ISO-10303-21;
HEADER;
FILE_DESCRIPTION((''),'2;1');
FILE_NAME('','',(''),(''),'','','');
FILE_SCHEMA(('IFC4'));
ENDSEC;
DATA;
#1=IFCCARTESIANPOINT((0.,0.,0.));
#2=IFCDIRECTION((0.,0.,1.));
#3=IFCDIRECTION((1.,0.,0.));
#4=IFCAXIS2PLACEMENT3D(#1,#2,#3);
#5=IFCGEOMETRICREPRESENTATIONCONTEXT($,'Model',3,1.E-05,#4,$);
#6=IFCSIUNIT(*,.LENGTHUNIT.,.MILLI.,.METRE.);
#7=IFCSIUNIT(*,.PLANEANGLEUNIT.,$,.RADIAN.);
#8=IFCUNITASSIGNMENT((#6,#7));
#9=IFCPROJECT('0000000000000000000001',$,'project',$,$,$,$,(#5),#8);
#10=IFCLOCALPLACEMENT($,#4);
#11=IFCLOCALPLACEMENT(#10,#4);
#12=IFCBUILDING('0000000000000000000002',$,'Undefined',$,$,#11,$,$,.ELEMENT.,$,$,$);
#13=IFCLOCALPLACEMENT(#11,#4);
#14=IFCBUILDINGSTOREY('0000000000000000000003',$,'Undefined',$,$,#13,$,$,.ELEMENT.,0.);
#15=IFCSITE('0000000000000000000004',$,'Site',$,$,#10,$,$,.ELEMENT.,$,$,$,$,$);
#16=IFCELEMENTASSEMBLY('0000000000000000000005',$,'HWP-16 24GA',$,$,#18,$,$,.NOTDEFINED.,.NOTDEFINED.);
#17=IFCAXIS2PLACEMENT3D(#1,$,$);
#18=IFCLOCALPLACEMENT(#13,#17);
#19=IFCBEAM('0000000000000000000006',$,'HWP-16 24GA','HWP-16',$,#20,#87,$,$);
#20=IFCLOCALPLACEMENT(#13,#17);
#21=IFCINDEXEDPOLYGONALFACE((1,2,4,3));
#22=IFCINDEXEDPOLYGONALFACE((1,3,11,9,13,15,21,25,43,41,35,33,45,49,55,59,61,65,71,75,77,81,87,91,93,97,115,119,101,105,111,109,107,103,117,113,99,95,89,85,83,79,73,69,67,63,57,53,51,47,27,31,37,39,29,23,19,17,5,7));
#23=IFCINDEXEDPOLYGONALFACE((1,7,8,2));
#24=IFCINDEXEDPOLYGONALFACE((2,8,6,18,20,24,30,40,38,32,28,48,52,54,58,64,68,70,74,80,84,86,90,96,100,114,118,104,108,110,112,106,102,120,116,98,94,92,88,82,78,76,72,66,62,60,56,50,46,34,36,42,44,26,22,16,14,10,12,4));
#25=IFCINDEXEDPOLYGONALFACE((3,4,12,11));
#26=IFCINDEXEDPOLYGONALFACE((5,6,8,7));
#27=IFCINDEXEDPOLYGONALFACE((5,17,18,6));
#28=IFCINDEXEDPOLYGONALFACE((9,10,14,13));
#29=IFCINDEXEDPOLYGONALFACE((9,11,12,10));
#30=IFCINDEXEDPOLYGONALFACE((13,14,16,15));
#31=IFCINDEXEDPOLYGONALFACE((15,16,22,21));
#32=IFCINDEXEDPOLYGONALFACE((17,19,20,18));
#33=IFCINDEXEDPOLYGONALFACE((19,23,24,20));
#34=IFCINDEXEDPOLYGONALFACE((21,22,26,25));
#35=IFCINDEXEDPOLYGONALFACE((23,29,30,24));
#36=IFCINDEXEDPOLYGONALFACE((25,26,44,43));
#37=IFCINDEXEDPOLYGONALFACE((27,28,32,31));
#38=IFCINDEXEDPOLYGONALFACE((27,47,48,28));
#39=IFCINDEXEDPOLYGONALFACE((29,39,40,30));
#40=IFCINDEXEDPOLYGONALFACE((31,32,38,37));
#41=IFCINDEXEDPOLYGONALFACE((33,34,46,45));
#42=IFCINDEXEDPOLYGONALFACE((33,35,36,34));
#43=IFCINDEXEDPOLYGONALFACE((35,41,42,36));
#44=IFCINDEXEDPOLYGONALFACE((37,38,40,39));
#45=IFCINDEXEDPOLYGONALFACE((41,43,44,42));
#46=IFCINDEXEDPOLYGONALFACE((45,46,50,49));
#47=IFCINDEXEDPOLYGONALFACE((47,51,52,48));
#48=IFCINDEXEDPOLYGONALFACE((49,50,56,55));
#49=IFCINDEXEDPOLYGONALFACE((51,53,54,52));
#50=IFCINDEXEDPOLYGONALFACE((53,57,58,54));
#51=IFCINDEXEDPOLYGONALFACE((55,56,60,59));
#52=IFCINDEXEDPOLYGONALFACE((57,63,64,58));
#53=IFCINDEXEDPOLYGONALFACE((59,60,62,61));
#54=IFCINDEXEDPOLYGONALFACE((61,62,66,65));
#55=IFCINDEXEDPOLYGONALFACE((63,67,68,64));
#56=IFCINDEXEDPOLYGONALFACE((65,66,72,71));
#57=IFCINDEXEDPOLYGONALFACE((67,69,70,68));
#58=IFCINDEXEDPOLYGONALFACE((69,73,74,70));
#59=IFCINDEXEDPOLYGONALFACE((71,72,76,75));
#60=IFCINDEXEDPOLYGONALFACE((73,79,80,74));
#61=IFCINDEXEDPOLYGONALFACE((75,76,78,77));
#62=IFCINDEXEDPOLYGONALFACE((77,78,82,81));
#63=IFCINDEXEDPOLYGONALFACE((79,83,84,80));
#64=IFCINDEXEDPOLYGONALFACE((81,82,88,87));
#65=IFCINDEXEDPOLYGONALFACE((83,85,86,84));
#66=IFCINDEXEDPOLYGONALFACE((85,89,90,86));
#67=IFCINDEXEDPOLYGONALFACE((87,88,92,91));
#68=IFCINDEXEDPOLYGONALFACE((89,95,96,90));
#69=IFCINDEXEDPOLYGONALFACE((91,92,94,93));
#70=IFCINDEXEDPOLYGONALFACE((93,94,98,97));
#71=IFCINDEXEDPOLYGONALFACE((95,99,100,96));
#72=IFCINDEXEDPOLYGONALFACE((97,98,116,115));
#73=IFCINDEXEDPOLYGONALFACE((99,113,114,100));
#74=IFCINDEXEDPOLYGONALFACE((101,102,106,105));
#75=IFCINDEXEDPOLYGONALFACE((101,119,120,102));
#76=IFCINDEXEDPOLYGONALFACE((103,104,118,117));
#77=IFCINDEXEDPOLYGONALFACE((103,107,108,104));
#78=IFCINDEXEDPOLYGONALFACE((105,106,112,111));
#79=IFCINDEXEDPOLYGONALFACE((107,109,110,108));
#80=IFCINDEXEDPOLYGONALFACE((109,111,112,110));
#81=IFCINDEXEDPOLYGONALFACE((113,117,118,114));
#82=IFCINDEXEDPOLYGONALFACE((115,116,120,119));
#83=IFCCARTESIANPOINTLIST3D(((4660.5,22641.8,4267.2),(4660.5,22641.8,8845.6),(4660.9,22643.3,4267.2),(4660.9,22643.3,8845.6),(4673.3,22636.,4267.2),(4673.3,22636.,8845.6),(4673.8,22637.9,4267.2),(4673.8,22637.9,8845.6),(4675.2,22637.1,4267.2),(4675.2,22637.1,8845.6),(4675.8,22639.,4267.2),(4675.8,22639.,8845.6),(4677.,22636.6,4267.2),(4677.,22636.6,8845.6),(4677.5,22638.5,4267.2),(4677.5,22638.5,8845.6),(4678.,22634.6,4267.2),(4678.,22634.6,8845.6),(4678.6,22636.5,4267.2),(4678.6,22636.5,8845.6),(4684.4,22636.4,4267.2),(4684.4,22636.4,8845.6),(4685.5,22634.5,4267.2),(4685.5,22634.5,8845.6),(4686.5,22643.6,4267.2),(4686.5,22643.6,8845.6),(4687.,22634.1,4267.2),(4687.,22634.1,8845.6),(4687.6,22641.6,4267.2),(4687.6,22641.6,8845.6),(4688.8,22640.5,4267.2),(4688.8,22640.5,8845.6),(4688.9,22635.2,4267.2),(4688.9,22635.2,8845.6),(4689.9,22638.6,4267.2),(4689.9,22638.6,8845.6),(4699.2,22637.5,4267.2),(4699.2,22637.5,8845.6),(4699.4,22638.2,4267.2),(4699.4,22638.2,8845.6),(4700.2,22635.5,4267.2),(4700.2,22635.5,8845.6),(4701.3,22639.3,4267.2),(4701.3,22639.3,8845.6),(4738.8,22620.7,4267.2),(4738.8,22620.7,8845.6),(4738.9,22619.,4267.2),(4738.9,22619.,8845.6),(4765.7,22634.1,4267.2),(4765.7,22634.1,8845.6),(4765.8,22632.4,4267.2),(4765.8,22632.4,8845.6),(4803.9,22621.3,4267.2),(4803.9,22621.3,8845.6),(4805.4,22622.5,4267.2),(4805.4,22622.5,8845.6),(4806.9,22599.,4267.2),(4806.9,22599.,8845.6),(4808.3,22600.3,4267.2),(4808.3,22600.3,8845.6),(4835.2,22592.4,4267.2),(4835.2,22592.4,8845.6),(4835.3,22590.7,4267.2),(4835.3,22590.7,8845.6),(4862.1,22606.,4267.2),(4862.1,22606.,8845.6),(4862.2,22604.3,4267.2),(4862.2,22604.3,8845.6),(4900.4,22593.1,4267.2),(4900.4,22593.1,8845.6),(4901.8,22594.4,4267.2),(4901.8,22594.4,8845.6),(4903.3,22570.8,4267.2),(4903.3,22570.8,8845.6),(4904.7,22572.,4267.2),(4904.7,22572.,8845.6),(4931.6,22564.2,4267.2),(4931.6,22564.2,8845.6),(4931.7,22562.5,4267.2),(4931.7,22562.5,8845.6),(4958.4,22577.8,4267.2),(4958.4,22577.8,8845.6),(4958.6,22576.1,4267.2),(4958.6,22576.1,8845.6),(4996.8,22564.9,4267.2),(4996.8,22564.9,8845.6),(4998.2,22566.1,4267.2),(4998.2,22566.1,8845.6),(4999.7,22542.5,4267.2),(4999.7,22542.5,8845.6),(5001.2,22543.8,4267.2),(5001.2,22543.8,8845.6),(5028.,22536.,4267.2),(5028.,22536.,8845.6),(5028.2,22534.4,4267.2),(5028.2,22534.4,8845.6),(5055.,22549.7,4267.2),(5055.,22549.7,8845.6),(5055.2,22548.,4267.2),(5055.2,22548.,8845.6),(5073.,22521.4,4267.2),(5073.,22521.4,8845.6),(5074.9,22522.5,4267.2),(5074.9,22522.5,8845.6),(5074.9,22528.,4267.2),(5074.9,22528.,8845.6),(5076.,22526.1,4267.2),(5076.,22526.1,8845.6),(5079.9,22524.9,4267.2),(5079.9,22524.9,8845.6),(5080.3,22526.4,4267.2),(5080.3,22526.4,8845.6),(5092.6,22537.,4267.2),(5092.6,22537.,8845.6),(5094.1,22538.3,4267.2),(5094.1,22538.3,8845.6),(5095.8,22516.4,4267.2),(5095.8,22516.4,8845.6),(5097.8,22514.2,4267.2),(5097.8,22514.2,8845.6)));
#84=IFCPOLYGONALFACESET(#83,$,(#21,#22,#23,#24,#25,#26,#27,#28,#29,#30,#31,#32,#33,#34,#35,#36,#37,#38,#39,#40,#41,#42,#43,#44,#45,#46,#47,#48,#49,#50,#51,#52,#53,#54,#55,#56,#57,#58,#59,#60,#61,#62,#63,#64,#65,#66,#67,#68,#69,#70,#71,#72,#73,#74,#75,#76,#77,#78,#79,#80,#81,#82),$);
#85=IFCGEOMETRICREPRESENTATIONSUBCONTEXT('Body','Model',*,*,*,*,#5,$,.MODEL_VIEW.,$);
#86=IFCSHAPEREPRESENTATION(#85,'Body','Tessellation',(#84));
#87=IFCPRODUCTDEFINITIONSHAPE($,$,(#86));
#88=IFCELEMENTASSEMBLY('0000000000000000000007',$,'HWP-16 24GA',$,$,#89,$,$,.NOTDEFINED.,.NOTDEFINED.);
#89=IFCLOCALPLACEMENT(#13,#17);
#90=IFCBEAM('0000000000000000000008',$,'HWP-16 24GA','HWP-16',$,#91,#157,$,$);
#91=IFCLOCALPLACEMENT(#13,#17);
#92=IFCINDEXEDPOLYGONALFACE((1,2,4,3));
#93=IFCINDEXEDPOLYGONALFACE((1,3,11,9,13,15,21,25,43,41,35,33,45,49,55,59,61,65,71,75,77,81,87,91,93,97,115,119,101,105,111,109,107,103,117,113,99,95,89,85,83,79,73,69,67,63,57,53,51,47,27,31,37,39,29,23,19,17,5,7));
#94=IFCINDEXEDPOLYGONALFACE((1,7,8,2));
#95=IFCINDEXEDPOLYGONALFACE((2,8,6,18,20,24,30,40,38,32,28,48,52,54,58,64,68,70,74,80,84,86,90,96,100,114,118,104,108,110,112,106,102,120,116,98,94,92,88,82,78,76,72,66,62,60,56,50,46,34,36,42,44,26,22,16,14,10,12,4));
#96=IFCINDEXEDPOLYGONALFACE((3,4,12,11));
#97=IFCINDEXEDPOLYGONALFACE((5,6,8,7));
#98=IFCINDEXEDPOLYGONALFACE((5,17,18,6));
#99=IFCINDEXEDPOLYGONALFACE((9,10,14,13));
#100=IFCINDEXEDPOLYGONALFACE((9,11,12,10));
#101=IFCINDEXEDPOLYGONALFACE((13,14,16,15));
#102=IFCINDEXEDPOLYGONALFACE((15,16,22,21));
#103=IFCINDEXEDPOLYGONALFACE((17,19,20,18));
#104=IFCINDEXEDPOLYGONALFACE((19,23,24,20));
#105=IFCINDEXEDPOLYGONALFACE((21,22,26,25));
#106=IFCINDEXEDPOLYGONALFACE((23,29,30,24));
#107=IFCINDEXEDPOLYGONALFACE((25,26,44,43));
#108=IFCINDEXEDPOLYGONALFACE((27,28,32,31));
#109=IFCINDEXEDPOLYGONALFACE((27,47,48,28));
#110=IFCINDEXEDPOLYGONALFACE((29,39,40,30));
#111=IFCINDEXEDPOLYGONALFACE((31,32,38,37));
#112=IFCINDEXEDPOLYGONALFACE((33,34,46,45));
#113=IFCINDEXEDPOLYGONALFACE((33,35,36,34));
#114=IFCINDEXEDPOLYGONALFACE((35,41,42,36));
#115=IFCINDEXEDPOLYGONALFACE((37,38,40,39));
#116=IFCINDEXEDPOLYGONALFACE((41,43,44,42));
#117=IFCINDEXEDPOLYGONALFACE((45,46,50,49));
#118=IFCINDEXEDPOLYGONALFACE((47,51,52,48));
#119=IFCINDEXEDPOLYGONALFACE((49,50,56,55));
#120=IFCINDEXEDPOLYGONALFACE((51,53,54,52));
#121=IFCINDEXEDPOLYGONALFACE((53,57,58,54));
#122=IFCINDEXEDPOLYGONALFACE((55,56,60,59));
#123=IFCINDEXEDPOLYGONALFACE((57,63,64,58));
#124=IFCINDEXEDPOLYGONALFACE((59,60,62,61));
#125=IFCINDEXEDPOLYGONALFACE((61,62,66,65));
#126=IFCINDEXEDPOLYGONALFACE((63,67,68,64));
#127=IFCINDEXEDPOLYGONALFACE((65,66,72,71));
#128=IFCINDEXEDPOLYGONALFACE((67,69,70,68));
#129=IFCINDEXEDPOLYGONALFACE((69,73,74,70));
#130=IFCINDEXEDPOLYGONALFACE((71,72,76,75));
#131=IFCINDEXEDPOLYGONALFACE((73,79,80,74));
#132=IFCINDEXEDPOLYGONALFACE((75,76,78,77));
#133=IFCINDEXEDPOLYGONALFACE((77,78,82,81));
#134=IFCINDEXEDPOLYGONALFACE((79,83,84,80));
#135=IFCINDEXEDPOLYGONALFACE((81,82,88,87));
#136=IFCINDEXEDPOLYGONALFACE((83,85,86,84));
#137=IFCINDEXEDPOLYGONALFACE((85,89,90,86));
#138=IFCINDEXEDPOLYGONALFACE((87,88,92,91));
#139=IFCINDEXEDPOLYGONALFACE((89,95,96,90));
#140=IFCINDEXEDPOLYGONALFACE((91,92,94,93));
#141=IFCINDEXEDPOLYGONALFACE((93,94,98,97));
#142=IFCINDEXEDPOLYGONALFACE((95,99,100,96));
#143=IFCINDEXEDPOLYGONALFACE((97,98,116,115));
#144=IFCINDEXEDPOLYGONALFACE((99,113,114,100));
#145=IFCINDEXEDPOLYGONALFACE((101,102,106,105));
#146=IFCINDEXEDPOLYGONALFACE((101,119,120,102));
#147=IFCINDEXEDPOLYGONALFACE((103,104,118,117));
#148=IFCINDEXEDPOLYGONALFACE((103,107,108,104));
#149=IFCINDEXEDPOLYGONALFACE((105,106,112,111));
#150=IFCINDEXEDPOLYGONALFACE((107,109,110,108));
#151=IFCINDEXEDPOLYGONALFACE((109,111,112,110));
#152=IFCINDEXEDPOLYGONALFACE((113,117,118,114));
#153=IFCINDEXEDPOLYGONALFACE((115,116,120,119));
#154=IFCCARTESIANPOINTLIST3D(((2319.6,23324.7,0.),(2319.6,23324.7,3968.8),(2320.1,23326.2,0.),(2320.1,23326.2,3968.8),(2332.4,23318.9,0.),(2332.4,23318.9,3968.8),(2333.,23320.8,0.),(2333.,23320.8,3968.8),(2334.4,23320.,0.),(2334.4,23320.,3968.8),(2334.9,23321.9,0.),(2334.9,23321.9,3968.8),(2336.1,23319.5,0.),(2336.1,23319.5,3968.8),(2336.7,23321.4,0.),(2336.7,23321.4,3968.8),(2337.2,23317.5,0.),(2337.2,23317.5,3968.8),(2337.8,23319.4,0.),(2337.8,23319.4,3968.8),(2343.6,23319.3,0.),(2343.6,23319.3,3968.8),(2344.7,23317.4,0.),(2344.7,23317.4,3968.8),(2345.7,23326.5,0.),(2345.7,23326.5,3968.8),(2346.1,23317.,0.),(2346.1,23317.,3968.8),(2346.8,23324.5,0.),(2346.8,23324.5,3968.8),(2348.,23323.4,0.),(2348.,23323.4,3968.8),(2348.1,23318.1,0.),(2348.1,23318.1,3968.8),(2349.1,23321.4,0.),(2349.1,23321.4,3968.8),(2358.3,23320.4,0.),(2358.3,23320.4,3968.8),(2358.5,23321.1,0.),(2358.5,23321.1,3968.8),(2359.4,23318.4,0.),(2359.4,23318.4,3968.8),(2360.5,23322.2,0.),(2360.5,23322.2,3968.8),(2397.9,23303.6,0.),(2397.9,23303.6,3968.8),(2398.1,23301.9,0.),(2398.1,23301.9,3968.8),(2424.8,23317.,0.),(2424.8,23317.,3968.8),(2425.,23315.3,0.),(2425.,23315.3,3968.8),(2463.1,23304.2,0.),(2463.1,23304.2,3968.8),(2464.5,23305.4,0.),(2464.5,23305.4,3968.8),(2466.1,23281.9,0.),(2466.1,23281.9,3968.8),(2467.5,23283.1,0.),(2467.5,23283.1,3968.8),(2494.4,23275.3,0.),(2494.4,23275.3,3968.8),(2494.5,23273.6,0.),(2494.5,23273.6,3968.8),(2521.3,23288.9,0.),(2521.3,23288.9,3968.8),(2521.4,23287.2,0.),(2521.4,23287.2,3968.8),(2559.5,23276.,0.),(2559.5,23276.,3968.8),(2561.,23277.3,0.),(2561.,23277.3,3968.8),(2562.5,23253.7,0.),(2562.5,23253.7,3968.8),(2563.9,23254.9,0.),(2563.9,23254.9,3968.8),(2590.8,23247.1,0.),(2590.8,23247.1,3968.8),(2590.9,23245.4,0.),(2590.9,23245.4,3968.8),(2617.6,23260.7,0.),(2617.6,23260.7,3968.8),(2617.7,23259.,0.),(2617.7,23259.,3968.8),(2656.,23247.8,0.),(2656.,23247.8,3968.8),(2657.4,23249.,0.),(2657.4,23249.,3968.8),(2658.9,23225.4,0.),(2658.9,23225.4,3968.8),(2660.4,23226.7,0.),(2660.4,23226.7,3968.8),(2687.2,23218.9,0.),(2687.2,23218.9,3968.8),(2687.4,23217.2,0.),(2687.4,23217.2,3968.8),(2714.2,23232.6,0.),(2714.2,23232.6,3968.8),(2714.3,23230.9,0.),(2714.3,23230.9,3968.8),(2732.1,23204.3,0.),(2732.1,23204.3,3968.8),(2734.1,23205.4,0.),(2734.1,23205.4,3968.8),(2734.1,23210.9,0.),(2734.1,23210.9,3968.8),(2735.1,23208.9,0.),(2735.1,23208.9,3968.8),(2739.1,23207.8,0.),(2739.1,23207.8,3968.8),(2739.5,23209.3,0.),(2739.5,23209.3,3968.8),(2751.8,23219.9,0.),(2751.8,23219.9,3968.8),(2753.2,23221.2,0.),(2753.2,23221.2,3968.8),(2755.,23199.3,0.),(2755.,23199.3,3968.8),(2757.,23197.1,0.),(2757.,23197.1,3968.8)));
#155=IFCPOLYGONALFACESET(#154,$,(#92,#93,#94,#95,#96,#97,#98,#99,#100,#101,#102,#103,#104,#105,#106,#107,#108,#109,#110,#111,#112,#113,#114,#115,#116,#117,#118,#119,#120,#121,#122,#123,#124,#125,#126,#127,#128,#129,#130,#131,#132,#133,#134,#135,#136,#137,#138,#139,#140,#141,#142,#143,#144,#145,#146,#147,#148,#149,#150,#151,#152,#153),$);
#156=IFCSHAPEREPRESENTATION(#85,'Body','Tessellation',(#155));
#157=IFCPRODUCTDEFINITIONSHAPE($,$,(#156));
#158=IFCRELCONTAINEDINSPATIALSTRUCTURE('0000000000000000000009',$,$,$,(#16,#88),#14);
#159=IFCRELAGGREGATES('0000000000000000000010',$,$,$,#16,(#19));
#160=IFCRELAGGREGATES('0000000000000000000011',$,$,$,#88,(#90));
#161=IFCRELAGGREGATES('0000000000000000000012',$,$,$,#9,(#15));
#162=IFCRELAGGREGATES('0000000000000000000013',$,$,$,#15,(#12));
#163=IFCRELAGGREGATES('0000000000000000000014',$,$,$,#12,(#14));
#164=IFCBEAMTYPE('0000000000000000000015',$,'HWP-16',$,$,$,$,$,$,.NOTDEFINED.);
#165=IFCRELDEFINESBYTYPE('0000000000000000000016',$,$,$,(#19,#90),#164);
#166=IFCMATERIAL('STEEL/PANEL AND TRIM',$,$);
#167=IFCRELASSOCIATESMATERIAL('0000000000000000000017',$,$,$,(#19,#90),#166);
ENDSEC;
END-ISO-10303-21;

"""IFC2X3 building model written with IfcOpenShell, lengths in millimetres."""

from ifc_helpers import new_model, si_unit, frame, origin_with_axes, place, context, subcontext, project, spatial, polyline, outline, extrude, boolean, clip, halfspace, material, type_object, element, aggregate, save


model = new_model("IFC2X3")

# Units and contexts
model_context = context("Model", 3, precision=1e-05, world=origin_with_axes())
body_context = subcontext(model_context, "Body", "Model", "MODEL_VIEW")
ifc_project = project(units=[si_unit("LENGTHUNIT", "METRE", prefix="MILLI"), si_unit("PLANEANGLEUNIT", "RADIAN")], contexts=[model_context])

# Site, building, storey
site_placement = place(None, origin_with_axes())
site = spatial("IfcSite", under=ifc_project, at=site_placement, Name="Site", CompositionType="ELEMENT")
building_placement = place(site_placement, origin_with_axes())
building = spatial("IfcBuilding", under=site, at=building_placement, Name="Undefined", CompositionType="ELEMENT")
storey_placement = place(building_placement, origin_with_axes())
storey = spatial("IfcBuildingStorey", under=building, at=storey_placement, Name="Undefined", CompositionType="ELEMENT", Elevation=0.0)

# Element assemblies, beams
ifc_material_1 = material(Name="STEEL/PANEL AND TRIM")
beam_type_1 = type_object("IfcBeamType", Name="HWP-16", PredefinedType="NOTDEFINED")
assembly_1_placement = place(storey_placement, origin_with_axes())
assembly_1 = element("IfcElementAssembly", 1, at=assembly_1_placement, inside=storey, Name="HWP-16 24GA", AssemblyPlace="NOTDEFINED", PredefinedType="NOTDEFINED")
beam_1_placement = place(assembly_1_placement, frame((5094.1, 22538.3, 8845.6), z_axis=(-0.280057, -0.959983, 0.0), x_axis=(0.0, 0.0, -1.0)))
beam_1 = element("IfcBeam", 2, at=beam_1_placement, type_object=beam_type_1, material=ifc_material_1, Name="HWP-16 24GA", Description="HWP-16", context=body_context, shape_type="Clipping", body=[
    clip(extrude(outline(polyline([(40.7, 0.0), (0.0, 0.0), (-10.3, 22.1), (15.5, 22.1), (15.5, 15.2), (9.9, 15.2), (9.9, 16.8), (13.9, 16.8), (13.9, 20.5), (-7.8, 20.5), (1.0, 1.6), (40.1, 1.6), (62.1, 22.2), (91.7, 22.3), (100.8, 1.7), (140.6, 1.7), (162.6, 22.2), (192.2, 22.2), (201.3, 1.6), (241.0, 1.6), (263.1, 22.1), (292.7, 22.1), (301.8, 1.6), (341.5, 1.6), (363.5, 22.0), (417.6, 22.0), (417.6, 15.3), (406.9, 15.3), (406.9, 14.6), (419.2, 14.6), (419.2, 22.1), (426.4, 22.1), (426.4, 24.0), (431.3, 24.0), (431.3, 22.1), (445.2, 22.1), (445.2, 20.5), (429.7, 20.5), (429.7, 22.5), (427.9, 22.5), (427.9, 20.5), (420.7, 20.5), (420.7, 13.0), (405.3, 13.0), (405.3, 16.9), (416.0, 16.9), (416.0, 20.4), (364.1, 20.4), (342.1, 0.0), (300.7, 0.0), (291.6, 20.5), (263.7, 20.5), (241.6, 0.0), (200.3, 0.0), (191.2, 20.6), (163.2, 20.6), (141.3, 0.1), (99.8, 0.1), (90.7, 20.7), (62.7, 20.6), (40.7, 0.0)])), frame((10000.0, 0.0, 0.0), z_axis=(-1.0, 0.0, 0.0), x_axis=(0.0, -1.0, 0.0)), (0.0, 0.0, 1.0), 10000.0), halfspace(frame((4578.4, -500.0, -500.0), z_axis=(1.0, 0.0, 0.0), x_axis=(0.0, 0.0, 1.0)), False)),
])
aggregate(assembly_1, [beam_1])
assembly_2_placement = place(storey_placement, origin_with_axes())
assembly_2 = element("IfcElementAssembly", 3, at=assembly_2_placement, inside=storey, Name="HWP-16 24GA", AssemblyPlace="NOTDEFINED", PredefinedType="NOTDEFINED")
beam_2_placement = place(assembly_2_placement, frame((2753.2, 23221.2, 3968.8), z_axis=(-0.280057, -0.959983, 0.0), x_axis=(0.0, 0.0, -1.0)))
beam_2 = element("IfcBeam", 4, at=beam_2_placement, type_object=beam_type_1, material=ifc_material_1, Name="HWP-16 24GA", Description="HWP-16", context=body_context, shape_type="CSG", body=[
    boolean("DIFFERENCE", boolean("DIFFERENCE", extrude(outline(polyline([(40.7, 0.0), (0.0, 0.0), (-10.3, 22.1), (15.5, 22.1), (15.5, 15.2), (9.9, 15.2), (9.9, 16.8), (13.9, 16.8), (13.9, 20.5), (-7.8, 20.5), (1.0, 1.6), (40.1, 1.6), (62.1, 22.2), (91.7, 22.3), (100.8, 1.7), (140.6, 1.7), (162.6, 22.2), (192.2, 22.2), (201.3, 1.6), (241.0, 1.6), (263.1, 22.1), (292.7, 22.1), (301.8, 1.6), (341.5, 1.6), (363.5, 22.0), (417.6, 22.0), (417.6, 15.3), (406.9, 15.3), (406.9, 14.6), (419.2, 14.6), (419.2, 22.1), (426.4, 22.1), (426.4, 24.0), (431.3, 24.0), (431.3, 22.1), (445.2, 22.1), (445.2, 20.5), (429.7, 20.5), (429.7, 22.5), (427.9, 22.5), (427.9, 20.5), (420.7, 20.5), (420.7, 13.0), (405.3, 13.0), (405.3, 16.9), (416.0, 16.9), (416.0, 20.4), (364.1, 20.4), (342.1, 0.0), (300.7, 0.0), (291.6, 20.5), (263.7, 20.5), (241.6, 0.0), (200.3, 0.0), (191.2, 20.6), (163.2, 20.6), (141.3, 0.1), (99.8, 0.1), (90.7, 20.7), (62.7, 20.6), (40.7, 0.0)])), frame((10000.0, 0.0, 0.0), z_axis=(-1.0, 0.0, 0.0), x_axis=(0.0, -1.0, 0.0)), (0.0, 0.0, 1.0), 10000.0), extrude(outline(polyline([(0.0, 0.0), (5029.2, 0.0), (5029.2, 609.6), (0.0, 609.6), (0.0, 0.0)])), frame((920.8, 5232.4, -10.0), z_axis=(0.0, 0.0, 1.0), x_axis=(0.0, -1.0, 0.0)), (0.0, 0.0, 1.0), 44.0)), halfspace(frame((3968.8, -500.0, -500.0), z_axis=(1.0, 0.0, 0.0), x_axis=(0.0, 0.0, 1.0)), False)),
])
aggregate(assembly_2, [beam_2])

save(model, "model.ifc")
